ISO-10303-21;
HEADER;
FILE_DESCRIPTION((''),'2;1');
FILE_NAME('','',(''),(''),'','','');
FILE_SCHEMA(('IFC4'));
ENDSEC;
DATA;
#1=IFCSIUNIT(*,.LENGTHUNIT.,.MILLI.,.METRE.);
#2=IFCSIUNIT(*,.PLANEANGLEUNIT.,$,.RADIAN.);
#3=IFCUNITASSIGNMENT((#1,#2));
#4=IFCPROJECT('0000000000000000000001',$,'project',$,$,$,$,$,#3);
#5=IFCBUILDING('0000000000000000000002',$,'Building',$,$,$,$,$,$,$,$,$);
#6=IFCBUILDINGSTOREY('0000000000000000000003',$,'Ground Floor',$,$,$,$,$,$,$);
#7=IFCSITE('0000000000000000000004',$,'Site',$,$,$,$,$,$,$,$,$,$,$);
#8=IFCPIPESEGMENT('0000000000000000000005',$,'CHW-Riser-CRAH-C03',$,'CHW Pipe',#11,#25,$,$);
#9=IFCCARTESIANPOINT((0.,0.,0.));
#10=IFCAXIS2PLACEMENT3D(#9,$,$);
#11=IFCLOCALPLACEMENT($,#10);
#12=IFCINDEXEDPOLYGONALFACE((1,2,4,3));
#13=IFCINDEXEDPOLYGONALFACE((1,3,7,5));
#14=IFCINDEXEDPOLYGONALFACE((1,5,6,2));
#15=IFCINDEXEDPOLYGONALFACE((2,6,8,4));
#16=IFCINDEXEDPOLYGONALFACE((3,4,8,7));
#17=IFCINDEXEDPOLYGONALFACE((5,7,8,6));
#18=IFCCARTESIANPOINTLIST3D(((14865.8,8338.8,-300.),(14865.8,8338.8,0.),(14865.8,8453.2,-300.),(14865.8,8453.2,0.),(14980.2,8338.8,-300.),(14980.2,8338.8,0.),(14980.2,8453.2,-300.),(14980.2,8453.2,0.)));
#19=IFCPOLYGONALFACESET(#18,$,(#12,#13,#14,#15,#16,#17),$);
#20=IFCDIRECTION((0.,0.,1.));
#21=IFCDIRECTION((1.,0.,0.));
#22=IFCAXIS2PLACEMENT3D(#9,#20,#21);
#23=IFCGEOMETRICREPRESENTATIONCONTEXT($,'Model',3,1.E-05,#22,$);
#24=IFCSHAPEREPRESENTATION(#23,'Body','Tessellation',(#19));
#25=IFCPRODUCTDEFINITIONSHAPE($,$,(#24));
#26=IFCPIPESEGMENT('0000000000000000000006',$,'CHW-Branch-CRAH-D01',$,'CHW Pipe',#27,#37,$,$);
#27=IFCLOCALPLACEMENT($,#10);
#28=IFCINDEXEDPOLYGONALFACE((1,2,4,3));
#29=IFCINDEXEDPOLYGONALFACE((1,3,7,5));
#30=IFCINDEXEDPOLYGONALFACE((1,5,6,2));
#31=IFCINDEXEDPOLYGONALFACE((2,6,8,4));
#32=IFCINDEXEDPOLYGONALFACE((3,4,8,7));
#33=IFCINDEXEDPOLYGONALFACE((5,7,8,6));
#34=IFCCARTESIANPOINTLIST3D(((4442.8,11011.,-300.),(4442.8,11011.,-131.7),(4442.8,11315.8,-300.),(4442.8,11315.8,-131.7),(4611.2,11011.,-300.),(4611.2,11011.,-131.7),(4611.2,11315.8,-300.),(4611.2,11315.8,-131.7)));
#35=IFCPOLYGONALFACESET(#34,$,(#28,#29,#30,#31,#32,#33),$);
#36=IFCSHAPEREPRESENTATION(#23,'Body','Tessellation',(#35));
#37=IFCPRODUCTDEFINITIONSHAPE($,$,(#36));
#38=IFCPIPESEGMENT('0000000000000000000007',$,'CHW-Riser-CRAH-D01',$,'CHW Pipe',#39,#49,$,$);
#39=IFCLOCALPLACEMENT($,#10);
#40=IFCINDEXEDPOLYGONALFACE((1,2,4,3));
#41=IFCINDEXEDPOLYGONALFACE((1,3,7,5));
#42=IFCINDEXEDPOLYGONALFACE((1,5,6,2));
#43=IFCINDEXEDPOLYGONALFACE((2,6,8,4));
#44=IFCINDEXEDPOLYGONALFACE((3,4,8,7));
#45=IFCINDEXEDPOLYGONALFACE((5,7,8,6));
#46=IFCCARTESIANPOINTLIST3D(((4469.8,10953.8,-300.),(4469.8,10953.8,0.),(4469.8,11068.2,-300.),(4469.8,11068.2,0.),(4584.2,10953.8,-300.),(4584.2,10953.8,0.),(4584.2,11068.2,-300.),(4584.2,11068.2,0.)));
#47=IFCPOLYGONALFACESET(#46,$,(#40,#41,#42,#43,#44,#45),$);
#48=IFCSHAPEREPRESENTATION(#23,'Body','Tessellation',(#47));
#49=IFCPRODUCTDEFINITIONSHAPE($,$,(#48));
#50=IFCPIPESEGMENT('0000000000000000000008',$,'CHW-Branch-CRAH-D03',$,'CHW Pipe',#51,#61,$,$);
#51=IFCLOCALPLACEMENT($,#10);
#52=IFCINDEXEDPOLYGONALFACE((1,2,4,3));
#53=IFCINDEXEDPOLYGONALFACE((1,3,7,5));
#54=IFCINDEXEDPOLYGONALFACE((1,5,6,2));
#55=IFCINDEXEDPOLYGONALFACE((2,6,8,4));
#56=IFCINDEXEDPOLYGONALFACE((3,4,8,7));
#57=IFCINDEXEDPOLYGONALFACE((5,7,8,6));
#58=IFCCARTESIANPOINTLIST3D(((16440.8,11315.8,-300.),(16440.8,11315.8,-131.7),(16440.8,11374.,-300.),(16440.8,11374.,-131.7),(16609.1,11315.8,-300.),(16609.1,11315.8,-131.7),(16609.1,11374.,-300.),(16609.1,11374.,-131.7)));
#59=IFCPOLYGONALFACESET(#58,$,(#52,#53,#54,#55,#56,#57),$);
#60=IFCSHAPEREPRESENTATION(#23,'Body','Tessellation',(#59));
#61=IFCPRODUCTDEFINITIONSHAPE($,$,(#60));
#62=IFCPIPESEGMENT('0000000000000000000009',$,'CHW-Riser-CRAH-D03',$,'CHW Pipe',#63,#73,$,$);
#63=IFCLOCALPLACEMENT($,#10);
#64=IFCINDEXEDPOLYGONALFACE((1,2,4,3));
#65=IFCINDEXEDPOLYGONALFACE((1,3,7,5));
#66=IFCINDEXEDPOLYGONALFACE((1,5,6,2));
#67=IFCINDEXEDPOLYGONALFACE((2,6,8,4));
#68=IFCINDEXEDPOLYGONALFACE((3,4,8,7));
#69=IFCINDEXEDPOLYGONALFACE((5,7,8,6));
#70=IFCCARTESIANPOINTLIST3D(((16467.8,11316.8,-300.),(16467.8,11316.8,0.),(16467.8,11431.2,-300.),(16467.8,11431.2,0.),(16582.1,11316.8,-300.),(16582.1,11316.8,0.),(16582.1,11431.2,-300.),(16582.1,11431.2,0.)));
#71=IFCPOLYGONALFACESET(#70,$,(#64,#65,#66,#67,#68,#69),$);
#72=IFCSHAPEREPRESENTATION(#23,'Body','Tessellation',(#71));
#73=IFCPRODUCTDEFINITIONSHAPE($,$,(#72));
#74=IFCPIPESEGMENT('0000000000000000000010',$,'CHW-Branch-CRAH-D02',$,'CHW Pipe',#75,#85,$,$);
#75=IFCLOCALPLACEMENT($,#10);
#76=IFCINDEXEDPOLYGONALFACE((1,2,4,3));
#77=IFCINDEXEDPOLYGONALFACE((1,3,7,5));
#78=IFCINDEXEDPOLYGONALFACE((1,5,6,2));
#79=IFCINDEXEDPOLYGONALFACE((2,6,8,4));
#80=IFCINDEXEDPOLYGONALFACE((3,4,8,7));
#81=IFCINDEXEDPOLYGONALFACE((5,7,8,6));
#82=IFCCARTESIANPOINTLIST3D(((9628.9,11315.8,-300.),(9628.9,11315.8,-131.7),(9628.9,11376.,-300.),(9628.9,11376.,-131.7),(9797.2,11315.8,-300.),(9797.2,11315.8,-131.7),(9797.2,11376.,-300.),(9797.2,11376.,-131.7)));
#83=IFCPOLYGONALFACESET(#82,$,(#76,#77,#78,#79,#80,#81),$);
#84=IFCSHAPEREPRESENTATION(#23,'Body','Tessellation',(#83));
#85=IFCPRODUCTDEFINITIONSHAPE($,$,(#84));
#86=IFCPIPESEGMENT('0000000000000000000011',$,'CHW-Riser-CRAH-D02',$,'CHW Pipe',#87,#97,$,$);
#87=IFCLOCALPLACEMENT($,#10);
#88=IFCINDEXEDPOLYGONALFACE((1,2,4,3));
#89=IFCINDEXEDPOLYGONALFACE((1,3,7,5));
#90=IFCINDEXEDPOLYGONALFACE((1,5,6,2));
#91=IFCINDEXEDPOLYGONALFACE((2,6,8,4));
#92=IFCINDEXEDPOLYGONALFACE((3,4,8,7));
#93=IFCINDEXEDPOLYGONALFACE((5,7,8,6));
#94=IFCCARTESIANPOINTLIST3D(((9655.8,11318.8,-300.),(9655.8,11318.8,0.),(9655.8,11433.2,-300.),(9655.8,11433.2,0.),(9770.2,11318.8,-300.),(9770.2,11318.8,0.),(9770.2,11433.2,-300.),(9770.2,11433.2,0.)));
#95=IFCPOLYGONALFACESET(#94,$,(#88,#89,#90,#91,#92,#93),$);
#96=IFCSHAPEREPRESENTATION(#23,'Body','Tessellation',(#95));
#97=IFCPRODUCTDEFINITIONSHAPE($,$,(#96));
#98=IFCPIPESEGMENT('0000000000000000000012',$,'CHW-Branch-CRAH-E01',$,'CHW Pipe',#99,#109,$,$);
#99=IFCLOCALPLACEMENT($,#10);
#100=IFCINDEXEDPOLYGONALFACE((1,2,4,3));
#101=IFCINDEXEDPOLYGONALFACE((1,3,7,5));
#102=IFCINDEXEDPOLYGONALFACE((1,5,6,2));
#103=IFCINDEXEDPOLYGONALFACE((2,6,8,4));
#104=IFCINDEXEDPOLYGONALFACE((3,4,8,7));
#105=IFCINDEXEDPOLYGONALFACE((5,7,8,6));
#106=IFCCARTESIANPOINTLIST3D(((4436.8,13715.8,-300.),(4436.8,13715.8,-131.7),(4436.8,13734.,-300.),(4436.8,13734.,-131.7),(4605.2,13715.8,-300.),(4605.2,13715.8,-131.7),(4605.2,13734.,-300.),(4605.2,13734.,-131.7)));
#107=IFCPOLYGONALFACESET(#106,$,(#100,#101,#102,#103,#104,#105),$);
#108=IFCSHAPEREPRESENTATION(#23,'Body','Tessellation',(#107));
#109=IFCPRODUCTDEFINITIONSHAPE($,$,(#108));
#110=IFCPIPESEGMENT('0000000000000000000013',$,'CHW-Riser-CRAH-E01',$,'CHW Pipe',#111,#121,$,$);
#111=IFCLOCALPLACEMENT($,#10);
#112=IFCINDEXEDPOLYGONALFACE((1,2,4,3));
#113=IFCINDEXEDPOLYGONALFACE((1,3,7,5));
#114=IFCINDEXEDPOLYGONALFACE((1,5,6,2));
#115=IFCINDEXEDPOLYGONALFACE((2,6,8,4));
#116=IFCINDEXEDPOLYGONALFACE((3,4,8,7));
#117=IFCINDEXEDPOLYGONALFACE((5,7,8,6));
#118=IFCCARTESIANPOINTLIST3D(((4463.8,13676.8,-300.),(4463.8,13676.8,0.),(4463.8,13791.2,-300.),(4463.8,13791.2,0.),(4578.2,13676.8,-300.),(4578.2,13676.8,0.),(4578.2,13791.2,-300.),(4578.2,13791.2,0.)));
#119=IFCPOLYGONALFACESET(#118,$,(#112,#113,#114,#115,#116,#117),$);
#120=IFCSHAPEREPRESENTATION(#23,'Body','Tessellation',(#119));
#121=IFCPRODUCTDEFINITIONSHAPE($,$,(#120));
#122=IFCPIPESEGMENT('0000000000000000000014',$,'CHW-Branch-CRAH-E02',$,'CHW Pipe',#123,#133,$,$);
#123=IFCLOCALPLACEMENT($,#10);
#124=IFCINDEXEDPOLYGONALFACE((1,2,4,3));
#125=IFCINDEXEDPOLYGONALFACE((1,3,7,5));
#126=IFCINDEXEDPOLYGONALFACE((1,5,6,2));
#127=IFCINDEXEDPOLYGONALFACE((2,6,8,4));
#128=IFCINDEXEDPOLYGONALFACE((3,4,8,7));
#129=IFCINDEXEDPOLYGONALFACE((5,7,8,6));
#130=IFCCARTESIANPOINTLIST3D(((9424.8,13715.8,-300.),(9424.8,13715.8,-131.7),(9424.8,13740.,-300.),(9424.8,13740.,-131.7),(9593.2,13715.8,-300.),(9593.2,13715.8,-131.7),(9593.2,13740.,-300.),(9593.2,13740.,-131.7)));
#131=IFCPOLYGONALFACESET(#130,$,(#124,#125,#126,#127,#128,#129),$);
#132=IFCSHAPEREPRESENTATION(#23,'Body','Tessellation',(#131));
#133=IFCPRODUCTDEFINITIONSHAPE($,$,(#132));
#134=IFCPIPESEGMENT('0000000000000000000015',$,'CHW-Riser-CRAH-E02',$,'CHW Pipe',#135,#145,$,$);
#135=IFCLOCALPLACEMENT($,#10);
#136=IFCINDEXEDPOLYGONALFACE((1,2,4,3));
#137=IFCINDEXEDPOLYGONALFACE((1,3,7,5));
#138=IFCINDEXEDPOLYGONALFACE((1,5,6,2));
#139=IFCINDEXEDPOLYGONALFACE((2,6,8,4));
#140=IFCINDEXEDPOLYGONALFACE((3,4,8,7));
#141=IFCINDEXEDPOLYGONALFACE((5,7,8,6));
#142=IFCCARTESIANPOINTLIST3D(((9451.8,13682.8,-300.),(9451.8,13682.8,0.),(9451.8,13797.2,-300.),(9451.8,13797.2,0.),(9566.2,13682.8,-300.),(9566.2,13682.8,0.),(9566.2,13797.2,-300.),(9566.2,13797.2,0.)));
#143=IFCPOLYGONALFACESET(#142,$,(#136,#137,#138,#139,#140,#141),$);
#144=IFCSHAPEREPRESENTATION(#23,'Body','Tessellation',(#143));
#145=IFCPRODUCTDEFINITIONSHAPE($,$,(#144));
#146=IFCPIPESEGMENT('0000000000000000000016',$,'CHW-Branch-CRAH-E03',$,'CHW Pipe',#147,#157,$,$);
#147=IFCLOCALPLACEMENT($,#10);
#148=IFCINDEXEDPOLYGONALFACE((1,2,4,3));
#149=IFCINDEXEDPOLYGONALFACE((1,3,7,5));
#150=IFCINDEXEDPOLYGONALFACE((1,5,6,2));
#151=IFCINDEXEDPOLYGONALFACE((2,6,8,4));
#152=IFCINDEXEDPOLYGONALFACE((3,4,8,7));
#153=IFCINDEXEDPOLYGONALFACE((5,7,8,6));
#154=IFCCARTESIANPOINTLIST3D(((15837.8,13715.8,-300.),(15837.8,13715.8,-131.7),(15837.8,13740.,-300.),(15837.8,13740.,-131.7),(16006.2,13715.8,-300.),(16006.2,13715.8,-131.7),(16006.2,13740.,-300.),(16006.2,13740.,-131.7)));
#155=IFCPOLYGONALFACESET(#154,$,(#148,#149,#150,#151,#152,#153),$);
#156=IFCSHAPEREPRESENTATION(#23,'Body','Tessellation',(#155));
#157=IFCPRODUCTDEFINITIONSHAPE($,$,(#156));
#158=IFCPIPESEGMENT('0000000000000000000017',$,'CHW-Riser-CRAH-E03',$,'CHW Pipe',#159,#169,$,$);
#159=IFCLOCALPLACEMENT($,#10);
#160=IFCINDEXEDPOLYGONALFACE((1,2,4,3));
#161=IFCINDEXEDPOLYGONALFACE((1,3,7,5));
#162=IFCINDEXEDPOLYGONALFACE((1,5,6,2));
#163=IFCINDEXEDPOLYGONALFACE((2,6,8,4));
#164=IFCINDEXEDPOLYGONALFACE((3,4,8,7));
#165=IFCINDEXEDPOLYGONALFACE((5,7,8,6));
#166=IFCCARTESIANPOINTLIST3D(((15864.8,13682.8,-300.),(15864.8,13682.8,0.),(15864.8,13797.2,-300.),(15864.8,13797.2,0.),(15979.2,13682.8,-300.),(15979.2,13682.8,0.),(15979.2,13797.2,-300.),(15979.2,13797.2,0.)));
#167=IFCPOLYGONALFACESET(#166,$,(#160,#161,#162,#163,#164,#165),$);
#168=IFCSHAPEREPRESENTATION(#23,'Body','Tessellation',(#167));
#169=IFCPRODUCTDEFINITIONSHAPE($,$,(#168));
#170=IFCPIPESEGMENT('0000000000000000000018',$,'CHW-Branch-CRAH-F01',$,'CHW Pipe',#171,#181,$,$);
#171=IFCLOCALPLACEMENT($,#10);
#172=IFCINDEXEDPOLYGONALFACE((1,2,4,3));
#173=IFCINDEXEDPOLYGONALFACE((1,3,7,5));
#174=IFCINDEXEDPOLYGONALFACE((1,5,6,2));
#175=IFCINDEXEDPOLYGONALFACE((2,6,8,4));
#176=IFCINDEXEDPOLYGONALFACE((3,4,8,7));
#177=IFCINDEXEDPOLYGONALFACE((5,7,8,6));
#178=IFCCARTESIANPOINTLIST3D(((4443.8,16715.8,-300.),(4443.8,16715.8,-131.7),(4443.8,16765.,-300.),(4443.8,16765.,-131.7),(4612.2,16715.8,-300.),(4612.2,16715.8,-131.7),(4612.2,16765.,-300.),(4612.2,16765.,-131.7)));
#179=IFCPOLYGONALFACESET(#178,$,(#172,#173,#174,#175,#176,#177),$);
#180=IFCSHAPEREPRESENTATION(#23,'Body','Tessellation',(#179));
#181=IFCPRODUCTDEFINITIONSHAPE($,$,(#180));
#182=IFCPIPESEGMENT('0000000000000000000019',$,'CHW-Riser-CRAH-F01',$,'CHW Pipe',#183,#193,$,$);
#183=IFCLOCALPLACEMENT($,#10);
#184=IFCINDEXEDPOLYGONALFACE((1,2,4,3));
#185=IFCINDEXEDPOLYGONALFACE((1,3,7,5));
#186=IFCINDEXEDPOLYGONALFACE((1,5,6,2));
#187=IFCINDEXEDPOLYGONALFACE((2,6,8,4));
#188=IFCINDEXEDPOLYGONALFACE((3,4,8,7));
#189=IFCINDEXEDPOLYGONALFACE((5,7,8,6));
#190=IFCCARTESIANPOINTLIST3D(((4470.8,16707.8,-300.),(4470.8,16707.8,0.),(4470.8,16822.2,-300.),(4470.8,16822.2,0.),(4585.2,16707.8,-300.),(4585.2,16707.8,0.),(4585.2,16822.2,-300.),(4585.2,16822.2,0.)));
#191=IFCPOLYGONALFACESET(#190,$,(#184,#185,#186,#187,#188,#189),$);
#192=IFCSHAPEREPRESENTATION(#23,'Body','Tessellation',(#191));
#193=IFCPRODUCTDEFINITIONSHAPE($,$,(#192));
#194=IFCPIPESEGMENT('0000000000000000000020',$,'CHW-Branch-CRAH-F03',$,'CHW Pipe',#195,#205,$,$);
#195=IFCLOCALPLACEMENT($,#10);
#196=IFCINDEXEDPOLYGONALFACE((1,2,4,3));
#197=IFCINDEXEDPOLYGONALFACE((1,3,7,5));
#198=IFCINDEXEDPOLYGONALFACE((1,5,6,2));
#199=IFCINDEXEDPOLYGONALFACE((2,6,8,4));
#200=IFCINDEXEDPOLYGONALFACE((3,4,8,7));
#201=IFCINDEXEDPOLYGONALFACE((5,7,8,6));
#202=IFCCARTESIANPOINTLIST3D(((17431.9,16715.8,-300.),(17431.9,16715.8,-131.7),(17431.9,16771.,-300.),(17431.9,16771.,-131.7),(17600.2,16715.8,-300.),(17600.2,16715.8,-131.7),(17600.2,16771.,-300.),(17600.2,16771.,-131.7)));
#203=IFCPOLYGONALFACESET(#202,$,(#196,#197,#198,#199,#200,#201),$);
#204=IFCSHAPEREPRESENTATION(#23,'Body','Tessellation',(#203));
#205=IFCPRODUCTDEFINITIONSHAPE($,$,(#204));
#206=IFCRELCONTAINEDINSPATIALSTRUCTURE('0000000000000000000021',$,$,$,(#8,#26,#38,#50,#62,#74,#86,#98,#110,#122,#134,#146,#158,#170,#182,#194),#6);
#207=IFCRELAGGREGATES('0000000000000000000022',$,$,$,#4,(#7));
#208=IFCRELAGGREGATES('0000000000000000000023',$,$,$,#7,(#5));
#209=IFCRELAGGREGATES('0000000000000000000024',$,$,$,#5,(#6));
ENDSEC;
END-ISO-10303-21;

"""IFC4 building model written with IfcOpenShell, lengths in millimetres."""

from ifc_helpers import new_model, si_unit, frame, origin_with_axes, place, context, project, spatial, rectangle, extrude, element, save


model = new_model("IFC4")

# Units and contexts
model_context = context("Model", 3, precision=1e-05, world=origin_with_axes())
ifc_project = project(units=[si_unit("LENGTHUNIT", "METRE", prefix="MILLI"), si_unit("PLANEANGLEUNIT", "RADIAN")])

# Site, building, storey
site = spatial("IfcSite", under=ifc_project, Name="Site")
building = spatial("IfcBuilding", under=site, Name="Building")
storey = spatial("IfcBuildingStorey", under=building, Name="Ground Floor")

# Pipe segments
pipe_segment_1_placement = place(None, origin_with_axes())
element("IfcPipeSegment", 1, at=pipe_segment_1_placement, inside=storey, Name="CHW-Riser-CRAH-C03", ObjectType="CHW Pipe", context=model_context, shape_type="SweptSolid", body=[
    extrude(rectangle(XDim=114.3, YDim=114.3), frame((14923.0, 8396.0, -300.0), z_axis=(0.0, 0.0, 1.0), x_axis=(1.0, 0.0, 0.0)), (0.0, 0.0, 1.0), 300.0),
])
pipe_segment_2_placement = place(None, origin_with_axes())
element("IfcPipeSegment", 2, at=pipe_segment_2_placement, inside=storey, Name="CHW-Branch-CRAH-D01", ObjectType="CHW Pipe", context=model_context, shape_type="SweptSolid", body=[
    extrude(rectangle(XDim=168.3, YDim=304.9), frame((4527.0, 11163.4, -300.0), z_axis=(0.0, 0.0, 1.0), x_axis=(1.0, 0.0, 0.0)), (0.0, 0.0, 1.0), 168.3),
])
pipe_segment_3_placement = place(None, origin_with_axes())
element("IfcPipeSegment", 3, at=pipe_segment_3_placement, inside=storey, Name="CHW-Riser-CRAH-D01", ObjectType="CHW Pipe", context=model_context, shape_type="SweptSolid", body=[
    extrude(rectangle(XDim=114.3, YDim=114.3), frame((4527.0, 11011.0, -300.0), z_axis=(0.0, 0.0, 1.0), x_axis=(1.0, 0.0, 0.0)), (0.0, 0.0, 1.0), 300.0),
])
pipe_segment_4_placement = place(None, origin_with_axes())
element("IfcPipeSegment", 4, at=pipe_segment_4_placement, inside=storey, Name="CHW-Branch-CRAH-D03", ObjectType="CHW Pipe", context=model_context, shape_type="SweptSolid", body=[
    extrude(rectangle(XDim=168.3, YDim=58.1), frame((16525.0, 11344.9, -300.0), z_axis=(0.0, 0.0, 1.0), x_axis=(1.0, 0.0, 0.0)), (0.0, 0.0, 1.0), 168.3),
])
pipe_segment_5_placement = place(None, origin_with_axes())
element("IfcPipeSegment", 5, at=pipe_segment_5_placement, inside=storey, Name="CHW-Riser-CRAH-D03", ObjectType="CHW Pipe", context=model_context, shape_type="SweptSolid", body=[
    extrude(rectangle(XDim=114.3, YDim=114.3), frame((16525.0, 11374.0, -300.0), z_axis=(0.0, 0.0, 1.0), x_axis=(1.0, 0.0, 0.0)), (0.0, 0.0, 1.0), 300.0),
])
pipe_segment_6_placement = place(None, origin_with_axes())
element("IfcPipeSegment", 6, at=pipe_segment_6_placement, inside=storey, Name="CHW-Branch-CRAH-D02", ObjectType="CHW Pipe", context=model_context, shape_type="SweptSolid", body=[
    extrude(rectangle(XDim=168.3, YDim=60.1), frame((9713.0, 11345.9, -300.0), z_axis=(0.0, 0.0, 1.0), x_axis=(1.0, 0.0, 0.0)), (0.0, 0.0, 1.0), 168.3),
])
pipe_segment_7_placement = place(None, origin_with_axes())
element("IfcPipeSegment", 7, at=pipe_segment_7_placement, inside=storey, Name="CHW-Riser-CRAH-D02", ObjectType="CHW Pipe", context=model_context, shape_type="SweptSolid", body=[
    extrude(rectangle(XDim=114.3, YDim=114.3), frame((9713.0, 11376.0, -300.0), z_axis=(0.0, 0.0, 1.0), x_axis=(1.0, 0.0, 0.0)), (0.0, 0.0, 1.0), 300.0),
])
pipe_segment_8_placement = place(None, origin_with_axes())
element("IfcPipeSegment", 8, at=pipe_segment_8_placement, inside=storey, Name="CHW-Branch-CRAH-E01", ObjectType="CHW Pipe", context=model_context, shape_type="SweptSolid", body=[
    extrude(rectangle(XDim=168.3, YDim=18.1), frame((4521.0, 13724.9, -300.0), z_axis=(0.0, 0.0, 1.0), x_axis=(1.0, 0.0, 0.0)), (0.0, 0.0, 1.0), 168.3),
])
pipe_segment_9_placement = place(None, origin_with_axes())
element("IfcPipeSegment", 9, at=pipe_segment_9_placement, inside=storey, Name="CHW-Riser-CRAH-E01", ObjectType="CHW Pipe", context=model_context, shape_type="SweptSolid", body=[
    extrude(rectangle(XDim=114.3, YDim=114.3), frame((4521.0, 13734.0, -300.0), z_axis=(0.0, 0.0, 1.0), x_axis=(1.0, 0.0, 0.0)), (0.0, 0.0, 1.0), 300.0),
])
pipe_segment_10_placement = place(None, origin_with_axes())
element("IfcPipeSegment", 10, at=pipe_segment_10_placement, inside=storey, Name="CHW-Branch-CRAH-E02", ObjectType="CHW Pipe", context=model_context, shape_type="SweptSolid", body=[
    extrude(rectangle(XDim=168.3, YDim=24.1), frame((9509.0, 13727.9, -300.0), z_axis=(0.0, 0.0, 1.0), x_axis=(1.0, 0.0, 0.0)), (0.0, 0.0, 1.0), 168.3),
])
pipe_segment_11_placement = place(None, origin_with_axes())
element("IfcPipeSegment", 11, at=pipe_segment_11_placement, inside=storey, Name="CHW-Riser-CRAH-E02", ObjectType="CHW Pipe", context=model_context, shape_type="SweptSolid", body=[
    extrude(rectangle(XDim=114.3, YDim=114.3), frame((9509.0, 13740.0, -300.0), z_axis=(0.0, 0.0, 1.0), x_axis=(1.0, 0.0, 0.0)), (0.0, 0.0, 1.0), 300.0),
])
pipe_segment_12_placement = place(None, origin_with_axes())
element("IfcPipeSegment", 12, at=pipe_segment_12_placement, inside=storey, Name="CHW-Branch-CRAH-E03", ObjectType="CHW Pipe", context=model_context, shape_type="SweptSolid", body=[
    extrude(rectangle(XDim=168.3, YDim=24.1), frame((15922.0, 13727.9, -300.0), z_axis=(0.0, 0.0, 1.0), x_axis=(1.0, 0.0, 0.0)), (0.0, 0.0, 1.0), 168.3),
])
pipe_segment_13_placement = place(None, origin_with_axes())
element("IfcPipeSegment", 13, at=pipe_segment_13_placement, inside=storey, Name="CHW-Riser-CRAH-E03", ObjectType="CHW Pipe", context=model_context, shape_type="SweptSolid", body=[
    extrude(rectangle(XDim=114.3, YDim=114.3), frame((15922.0, 13740.0, -300.0), z_axis=(0.0, 0.0, 1.0), x_axis=(1.0, 0.0, 0.0)), (0.0, 0.0, 1.0), 300.0),
])
pipe_segment_14_placement = place(None, origin_with_axes())
element("IfcPipeSegment", 14, at=pipe_segment_14_placement, inside=storey, Name="CHW-Branch-CRAH-F01", ObjectType="CHW Pipe", context=model_context, shape_type="SweptSolid", body=[
    extrude(rectangle(XDim=168.3, YDim=49.2), frame((4528.0, 16740.4, -300.0), z_axis=(0.0, 0.0, 1.0), x_axis=(1.0, 0.0, 0.0)), (0.0, 0.0, 1.0), 168.3),
])
pipe_segment_15_placement = place(None, origin_with_axes())
element("IfcPipeSegment", 15, at=pipe_segment_15_placement, inside=storey, Name="CHW-Riser-CRAH-F01", ObjectType="CHW Pipe", context=model_context, shape_type="SweptSolid", body=[
    extrude(rectangle(XDim=114.3, YDim=114.3), frame((4528.0, 16765.0, -300.0), z_axis=(0.0, 0.0, 1.0), x_axis=(1.0, 0.0, 0.0)), (0.0, 0.0, 1.0), 300.0),
])
pipe_segment_16_placement = place(None, origin_with_axes())
element("IfcPipeSegment", 16, at=pipe_segment_16_placement, inside=storey, Name="CHW-Branch-CRAH-F03", ObjectType="CHW Pipe", context=model_context, shape_type="SweptSolid", body=[
    extrude(rectangle(XDim=168.3, YDim=55.2), frame((17516.0, 16743.4, -300.0), z_axis=(0.0, 0.0, 1.0), x_axis=(1.0, 0.0, 0.0)), (0.0, 0.0, 1.0), 168.3),
])

save(model, "model.ifc")
